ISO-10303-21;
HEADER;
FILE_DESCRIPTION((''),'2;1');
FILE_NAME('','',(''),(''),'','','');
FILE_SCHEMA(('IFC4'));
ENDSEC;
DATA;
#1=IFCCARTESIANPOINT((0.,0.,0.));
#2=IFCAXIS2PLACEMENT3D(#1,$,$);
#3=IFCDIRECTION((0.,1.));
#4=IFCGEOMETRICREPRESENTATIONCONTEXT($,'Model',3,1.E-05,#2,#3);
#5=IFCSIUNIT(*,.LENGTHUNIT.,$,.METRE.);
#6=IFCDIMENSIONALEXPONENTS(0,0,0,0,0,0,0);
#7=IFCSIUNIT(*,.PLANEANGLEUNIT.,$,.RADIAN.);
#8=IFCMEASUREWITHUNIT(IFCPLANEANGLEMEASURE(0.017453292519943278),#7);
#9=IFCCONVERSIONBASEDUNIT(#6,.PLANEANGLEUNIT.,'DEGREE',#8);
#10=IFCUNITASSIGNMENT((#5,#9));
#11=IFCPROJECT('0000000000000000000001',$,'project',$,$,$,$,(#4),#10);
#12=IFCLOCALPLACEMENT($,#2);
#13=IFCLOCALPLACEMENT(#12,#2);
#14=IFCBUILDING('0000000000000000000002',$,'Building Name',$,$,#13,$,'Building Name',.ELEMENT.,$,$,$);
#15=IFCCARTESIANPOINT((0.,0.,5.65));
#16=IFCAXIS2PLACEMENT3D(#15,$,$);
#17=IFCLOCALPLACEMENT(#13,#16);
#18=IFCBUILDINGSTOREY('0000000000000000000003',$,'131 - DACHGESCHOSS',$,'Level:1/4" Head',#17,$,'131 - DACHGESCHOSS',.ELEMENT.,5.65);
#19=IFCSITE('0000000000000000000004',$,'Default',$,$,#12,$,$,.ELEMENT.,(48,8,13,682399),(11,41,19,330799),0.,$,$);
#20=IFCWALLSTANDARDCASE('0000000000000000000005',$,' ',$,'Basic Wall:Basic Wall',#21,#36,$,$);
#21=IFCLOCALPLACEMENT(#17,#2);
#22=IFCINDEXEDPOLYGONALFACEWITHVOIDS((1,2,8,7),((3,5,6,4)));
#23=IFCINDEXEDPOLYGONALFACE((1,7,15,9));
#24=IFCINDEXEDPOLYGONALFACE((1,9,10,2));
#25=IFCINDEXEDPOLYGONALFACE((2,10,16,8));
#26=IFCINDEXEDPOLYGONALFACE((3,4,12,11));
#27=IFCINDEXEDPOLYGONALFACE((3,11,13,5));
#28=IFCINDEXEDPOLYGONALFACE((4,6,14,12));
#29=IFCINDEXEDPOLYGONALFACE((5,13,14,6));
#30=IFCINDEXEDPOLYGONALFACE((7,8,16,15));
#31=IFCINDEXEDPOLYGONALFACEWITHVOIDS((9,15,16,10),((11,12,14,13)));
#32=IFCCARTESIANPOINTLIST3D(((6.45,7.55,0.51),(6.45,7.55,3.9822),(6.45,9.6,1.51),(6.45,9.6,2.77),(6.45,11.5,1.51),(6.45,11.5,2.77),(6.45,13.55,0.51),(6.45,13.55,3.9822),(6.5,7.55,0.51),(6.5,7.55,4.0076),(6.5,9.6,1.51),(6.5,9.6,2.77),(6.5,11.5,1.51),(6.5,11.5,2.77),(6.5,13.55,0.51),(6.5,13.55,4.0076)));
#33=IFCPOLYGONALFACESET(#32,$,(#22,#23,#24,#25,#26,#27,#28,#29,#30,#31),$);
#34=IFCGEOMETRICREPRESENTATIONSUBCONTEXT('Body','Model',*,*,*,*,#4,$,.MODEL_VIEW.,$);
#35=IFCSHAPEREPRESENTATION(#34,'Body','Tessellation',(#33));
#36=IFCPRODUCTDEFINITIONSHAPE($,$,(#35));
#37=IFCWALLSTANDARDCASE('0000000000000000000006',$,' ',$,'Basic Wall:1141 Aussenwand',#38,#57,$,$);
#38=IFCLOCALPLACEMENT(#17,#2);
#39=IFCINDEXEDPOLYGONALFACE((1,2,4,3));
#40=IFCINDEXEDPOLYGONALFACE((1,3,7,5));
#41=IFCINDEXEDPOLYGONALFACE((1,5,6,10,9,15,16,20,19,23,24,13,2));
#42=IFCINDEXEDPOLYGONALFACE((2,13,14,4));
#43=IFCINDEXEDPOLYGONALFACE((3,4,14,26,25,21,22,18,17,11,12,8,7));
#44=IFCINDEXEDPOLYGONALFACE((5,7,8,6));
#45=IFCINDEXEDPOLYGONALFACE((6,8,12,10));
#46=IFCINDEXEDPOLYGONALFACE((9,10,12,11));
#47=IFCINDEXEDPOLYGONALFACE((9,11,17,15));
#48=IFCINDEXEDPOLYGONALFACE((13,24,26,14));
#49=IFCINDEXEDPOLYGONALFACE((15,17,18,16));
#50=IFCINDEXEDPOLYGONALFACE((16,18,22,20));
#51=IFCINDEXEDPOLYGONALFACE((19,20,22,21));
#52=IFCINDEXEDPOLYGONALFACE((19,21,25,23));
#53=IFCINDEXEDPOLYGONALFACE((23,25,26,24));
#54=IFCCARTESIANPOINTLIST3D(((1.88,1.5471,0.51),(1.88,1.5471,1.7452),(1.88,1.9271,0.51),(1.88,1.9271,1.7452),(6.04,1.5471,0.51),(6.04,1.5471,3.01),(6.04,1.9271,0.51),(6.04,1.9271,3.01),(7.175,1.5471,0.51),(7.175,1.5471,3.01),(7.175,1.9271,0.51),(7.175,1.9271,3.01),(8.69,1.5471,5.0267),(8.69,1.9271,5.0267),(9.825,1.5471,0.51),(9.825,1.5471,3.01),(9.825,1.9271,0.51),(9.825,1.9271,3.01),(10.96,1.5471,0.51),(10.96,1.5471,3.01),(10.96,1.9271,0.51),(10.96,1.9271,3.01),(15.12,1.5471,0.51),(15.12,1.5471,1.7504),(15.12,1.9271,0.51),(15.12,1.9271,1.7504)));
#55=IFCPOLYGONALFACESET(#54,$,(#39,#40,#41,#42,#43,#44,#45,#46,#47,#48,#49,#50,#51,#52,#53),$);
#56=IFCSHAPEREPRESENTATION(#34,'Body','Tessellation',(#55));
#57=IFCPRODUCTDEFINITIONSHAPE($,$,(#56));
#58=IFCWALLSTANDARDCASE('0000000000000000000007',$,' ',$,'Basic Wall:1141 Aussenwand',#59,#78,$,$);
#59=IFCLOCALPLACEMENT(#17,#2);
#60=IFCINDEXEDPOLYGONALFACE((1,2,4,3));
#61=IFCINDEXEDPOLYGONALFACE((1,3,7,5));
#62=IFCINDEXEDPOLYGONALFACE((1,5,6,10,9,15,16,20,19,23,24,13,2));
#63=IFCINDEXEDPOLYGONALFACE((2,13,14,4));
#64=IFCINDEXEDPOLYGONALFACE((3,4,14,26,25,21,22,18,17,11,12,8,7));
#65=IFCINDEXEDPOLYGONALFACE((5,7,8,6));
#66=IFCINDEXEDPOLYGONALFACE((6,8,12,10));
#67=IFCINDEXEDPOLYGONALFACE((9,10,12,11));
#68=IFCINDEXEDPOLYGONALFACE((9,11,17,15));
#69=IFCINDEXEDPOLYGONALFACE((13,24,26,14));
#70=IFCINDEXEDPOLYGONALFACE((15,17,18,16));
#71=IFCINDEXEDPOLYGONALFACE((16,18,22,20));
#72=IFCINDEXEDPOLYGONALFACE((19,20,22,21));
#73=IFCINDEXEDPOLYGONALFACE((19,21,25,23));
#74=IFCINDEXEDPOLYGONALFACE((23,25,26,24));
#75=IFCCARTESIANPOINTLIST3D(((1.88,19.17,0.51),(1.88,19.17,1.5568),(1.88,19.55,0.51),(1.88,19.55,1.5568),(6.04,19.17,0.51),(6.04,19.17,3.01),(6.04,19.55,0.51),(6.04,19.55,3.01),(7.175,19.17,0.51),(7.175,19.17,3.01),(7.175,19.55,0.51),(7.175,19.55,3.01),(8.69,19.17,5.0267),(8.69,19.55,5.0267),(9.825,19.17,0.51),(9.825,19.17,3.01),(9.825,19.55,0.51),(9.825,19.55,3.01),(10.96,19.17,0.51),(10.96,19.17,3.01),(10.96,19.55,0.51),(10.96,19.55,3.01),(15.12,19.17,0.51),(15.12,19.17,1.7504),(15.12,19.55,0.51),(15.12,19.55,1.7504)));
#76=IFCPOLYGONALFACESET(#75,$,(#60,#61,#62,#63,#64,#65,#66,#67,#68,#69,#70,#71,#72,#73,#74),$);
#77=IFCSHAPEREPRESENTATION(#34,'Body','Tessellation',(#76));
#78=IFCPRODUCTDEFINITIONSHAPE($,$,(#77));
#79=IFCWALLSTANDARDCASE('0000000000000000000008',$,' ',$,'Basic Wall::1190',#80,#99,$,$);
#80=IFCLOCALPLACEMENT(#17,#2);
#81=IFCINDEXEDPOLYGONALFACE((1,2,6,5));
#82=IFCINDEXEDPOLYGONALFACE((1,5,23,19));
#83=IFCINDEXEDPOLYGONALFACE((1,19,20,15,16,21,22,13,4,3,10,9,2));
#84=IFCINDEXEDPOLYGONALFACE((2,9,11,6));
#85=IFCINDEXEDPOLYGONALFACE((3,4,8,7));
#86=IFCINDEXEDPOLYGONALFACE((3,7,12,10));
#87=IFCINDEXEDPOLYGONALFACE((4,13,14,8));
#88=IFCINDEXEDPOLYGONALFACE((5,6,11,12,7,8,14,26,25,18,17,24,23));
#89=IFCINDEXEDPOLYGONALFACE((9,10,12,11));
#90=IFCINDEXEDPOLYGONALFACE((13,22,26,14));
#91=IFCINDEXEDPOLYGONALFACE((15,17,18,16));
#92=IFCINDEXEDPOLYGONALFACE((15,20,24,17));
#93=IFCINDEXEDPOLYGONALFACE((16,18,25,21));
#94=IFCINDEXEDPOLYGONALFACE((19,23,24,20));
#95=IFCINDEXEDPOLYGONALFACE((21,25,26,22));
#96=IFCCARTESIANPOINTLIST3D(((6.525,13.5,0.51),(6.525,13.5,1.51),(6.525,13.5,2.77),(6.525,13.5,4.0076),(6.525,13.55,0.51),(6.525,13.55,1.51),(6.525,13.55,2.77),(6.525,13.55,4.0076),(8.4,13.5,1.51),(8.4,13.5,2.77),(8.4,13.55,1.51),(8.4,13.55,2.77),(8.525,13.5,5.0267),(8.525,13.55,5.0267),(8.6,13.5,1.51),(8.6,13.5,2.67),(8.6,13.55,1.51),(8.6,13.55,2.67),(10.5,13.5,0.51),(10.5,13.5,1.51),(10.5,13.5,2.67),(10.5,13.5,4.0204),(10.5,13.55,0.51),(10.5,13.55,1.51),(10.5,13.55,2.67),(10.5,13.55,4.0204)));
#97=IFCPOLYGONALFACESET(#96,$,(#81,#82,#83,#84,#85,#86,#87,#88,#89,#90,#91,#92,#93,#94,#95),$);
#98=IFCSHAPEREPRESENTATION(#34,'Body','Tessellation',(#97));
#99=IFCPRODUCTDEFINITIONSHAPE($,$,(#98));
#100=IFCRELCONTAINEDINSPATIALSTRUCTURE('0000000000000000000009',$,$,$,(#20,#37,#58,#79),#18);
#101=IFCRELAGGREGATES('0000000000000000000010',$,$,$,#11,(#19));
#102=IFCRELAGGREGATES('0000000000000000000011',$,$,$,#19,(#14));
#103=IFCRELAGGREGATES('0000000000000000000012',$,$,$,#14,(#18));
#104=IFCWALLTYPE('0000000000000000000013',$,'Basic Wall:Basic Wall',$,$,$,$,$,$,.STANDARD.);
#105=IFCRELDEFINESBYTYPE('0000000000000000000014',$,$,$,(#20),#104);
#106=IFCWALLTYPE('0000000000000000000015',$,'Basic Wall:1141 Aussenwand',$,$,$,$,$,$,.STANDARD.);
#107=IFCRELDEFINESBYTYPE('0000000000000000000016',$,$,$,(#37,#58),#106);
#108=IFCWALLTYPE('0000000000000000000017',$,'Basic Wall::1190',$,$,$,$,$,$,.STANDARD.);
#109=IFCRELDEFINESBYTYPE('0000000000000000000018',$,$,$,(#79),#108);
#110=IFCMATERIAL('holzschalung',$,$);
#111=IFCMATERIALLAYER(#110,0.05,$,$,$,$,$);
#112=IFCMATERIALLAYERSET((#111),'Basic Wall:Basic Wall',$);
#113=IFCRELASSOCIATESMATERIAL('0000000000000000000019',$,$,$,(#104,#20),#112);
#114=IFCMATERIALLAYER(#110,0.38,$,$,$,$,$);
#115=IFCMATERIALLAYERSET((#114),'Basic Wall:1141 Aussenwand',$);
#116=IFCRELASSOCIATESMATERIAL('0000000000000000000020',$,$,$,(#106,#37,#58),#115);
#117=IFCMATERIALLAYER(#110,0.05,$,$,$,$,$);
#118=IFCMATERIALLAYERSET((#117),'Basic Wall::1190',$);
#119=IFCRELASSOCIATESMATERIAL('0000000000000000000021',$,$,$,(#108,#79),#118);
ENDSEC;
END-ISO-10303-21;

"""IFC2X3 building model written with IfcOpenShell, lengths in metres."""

from ifc_helpers import new_model, entity, si_unit, converted_unit, direction, frame, frame_2d, origin, place, context, subcontext, project, spatial, rectangle, extrude, clip, halfspace, material, layer, layer_set, layer_usage, type_object, element, save


model = new_model("IFC2X3")

# Units and contexts
model_context = context("Model", 3, precision=1e-05, world=origin(), true_north=direction((0.0, 1.0)))
body_context = subcontext(model_context, "Body", "Model", "MODEL_VIEW")
ifc_project = project(units=[si_unit("LENGTHUNIT", "METRE"), converted_unit("PLANEANGLEUNIT", "DEGREE", entity("IfcPlaneAngleMeasure", 0.017453292519943278), si_unit("PLANEANGLEUNIT", "RADIAN"), dimensions=[0, 0, 0, 0, 0, 0, 0])], contexts=[model_context])

# Site, building, storey
site_placement = place(None, origin())
site = spatial("IfcSite", under=ifc_project, at=site_placement, Name="Default", CompositionType="ELEMENT", RefLatitude=(48, 8, 13, 682399), RefLongitude=(11, 41, 19, 330799), RefElevation=0.0)
building_placement = place(site_placement, origin())
building = spatial("IfcBuilding", under=site, at=building_placement, Name="Building Name", LongName="Building Name", CompositionType="ELEMENT")
storey_placement = place(building_placement, frame((0.0, 0.0, 5.65)))
storey = spatial("IfcBuildingStorey", under=building, at=storey_placement, Name="131 - DACHGESCHOSS", ObjectType="Level:1/4\" Head", LongName="131 - DACHGESCHOSS", CompositionType="ELEMENT", Elevation=5.65)

# Shared definitions
ifc_material = material(Name="holzschalung")

# Wall, openings
ifc_layer_1 = layer(ifc_material, 0.05)
ifc_layer_set_1 = layer_set([ifc_layer_1], Name="Basic Wall:Basic Wall")
ifc_layer_usage_1 = layer_usage(ifc_layer_set_1, "AXIS2", "NEGATIVE", 0.025)
wall_type_1 = type_object("IfcWallType", Name="Basic Wall:Basic Wall", PredefinedType="STANDARD", material=ifc_layer_set_1)
wall_1_placement = place(storey_placement, frame((6.475, 7.55, 0.51), z_axis=(0.0, 0.0, 1.0), x_axis=(0.0, 1.0, 0.0)))
wall_1 = element("IfcWallStandardCase", 1, at=wall_1_placement, inside=storey, type_object=wall_type_1, material=ifc_layer_usage_1, Name=" ", ObjectType="Basic Wall:Basic Wall", context=body_context, shape_type="SweptSolid", body=[
    extrude(rectangle(XDim=6.0, YDim=0.05, at=frame_2d((3.0, 0.0), x_axis=(-1.0, 0.0))), origin(), (0.0, 0.0, 1.0), 3.4976),
])
opening_1_placement = place(wall_1_placement, origin())
element("IfcOpeningElement", 2, at=opening_1_placement, cuts=wall_1, ObjectType="Opening", context=body_context, shape_type="SweptSolid", body=[
    extrude(rectangle(XDim=6.9075, YDim=13.815, at=frame_2d((0.0, 0.0), x_axis=(1.0, 0.0))), frame((3.0, -3.177, 8.9799), z_axis=(0.0, 0.891007, -0.45399), x_axis=(0.0, -0.45399, -0.891007)), (0.0, 0.0, 1.0), 13.815),
])
opening_2_placement = place(wall_1_placement, origin())
element("IfcOpeningElement", 3, at=opening_2_placement, cuts=wall_1, ObjectType="Opening", context=body_context, shape_type="SweptSolid", body=[
    extrude(rectangle(XDim=1.26, YDim=1.9, at=frame_2d((0.0, 0.0), x_axis=(0.0, 1.0))), frame((3.0, -0.025, 1.63), z_axis=(0.0, 1.0, 0.0), x_axis=(-1.0, 0.0, 0.0)), (0.0, 0.0, 1.0), 0.05),
])

# Shared definitions
ifc_layer_2 = layer(ifc_material, 0.38)
ifc_layer_set_2 = layer_set([ifc_layer_2], Name="Basic Wall:1141 Aussenwand")
wall_type_2 = type_object("IfcWallType", Name="Basic Wall:1141 Aussenwand", PredefinedType="STANDARD", material=ifc_layer_set_2)

# Walls, openings
ifc_layer_usage_2 = layer_usage(ifc_layer_set_2, "AXIS2", "NEGATIVE", 0.19)
wall_2_placement = place(storey_placement, frame((15.12, 1.7371, 0.51), z_axis=(0.0, 0.0, 1.0), x_axis=(-1.0, 0.0, 0.0)))
wall_2 = element("IfcWallStandardCase", 4, at=wall_2_placement, inside=storey, type_object=wall_type_2, material=ifc_layer_usage_2, Name=" ", ObjectType="Basic Wall:1141 Aussenwand", context=body_context, shape_type="Clipping", body=[
    clip(clip(extrude(rectangle(XDim=13.24, YDim=0.38, at=frame_2d((6.62, 0.0), x_axis=(-1.0, 0.0))), origin(), (0.0, 0.0, 1.0), 4.5167), halfspace(frame((0.0, -0.19, 1.2404), z_axis=(-0.45399, 0.0, 0.891007), x_axis=(0.0, 1.0, 0.0)), False)), halfspace(frame((6.43, -0.19, 4.5167), z_axis=(0.434096, 0.0, 0.900866), x_axis=(0.0, 1.0, 0.0)), False)),
])
opening_3_placement = place(wall_2_placement, origin())
element("IfcOpeningElement", 5, at=opening_3_placement, cuts=wall_2, ObjectType="Opening", context=body_context, shape_type="SweptSolid", body=[
    extrude(rectangle(XDim=2.5, YDim=1.135, at=frame_2d((0.0, 0.0), x_axis=(1.0, 0.0))), frame((4.7275, -0.19, 1.25), z_axis=(0.0, 1.0, 0.0), x_axis=(0.0, 0.0, 1.0)), (0.0, 0.0, 1.0), 0.38),
])
opening_4_placement = place(wall_2_placement, origin())
element("IfcOpeningElement", 6, at=opening_4_placement, cuts=wall_2, ObjectType="Opening", context=body_context, shape_type="SweptSolid", body=[
    extrude(rectangle(XDim=2.5, YDim=1.135, at=frame_2d((0.0, 0.0), x_axis=(1.0, 0.0))), frame((8.5125, -0.19, 1.25), z_axis=(0.0, 1.0, 0.0), x_axis=(0.0, 0.0, 1.0)), (0.0, 0.0, 1.0), 0.38),
])
ifc_layer_usage_3 = layer_usage(ifc_layer_set_2, "AXIS2", "NEGATIVE", 0.19)
wall_3_placement = place(storey_placement, frame((1.88, 19.36, 0.51)))
wall_3 = element("IfcWallStandardCase", 7, at=wall_3_placement, inside=storey, type_object=wall_type_2, material=ifc_layer_usage_3, Name=" ", ObjectType="Basic Wall:1141 Aussenwand", context=body_context, shape_type="Clipping", body=[
    clip(clip(extrude(rectangle(XDim=13.24, YDim=0.38, at=frame_2d((6.62, 0.0), x_axis=(-1.0, 0.0))), origin(), (0.0, 0.0, 1.0), 4.5167), halfspace(frame((0.0, -0.19, 1.0468), z_axis=(-0.45399, 0.0, 0.891007), x_axis=(0.0, 1.0, 0.0)), False)), halfspace(frame((6.81, -0.19, 4.5167), z_axis=(0.45399, 0.0, 0.891007), x_axis=(0.0, 1.0, 0.0)), False)),
])
opening_5_placement = place(wall_3_placement, origin())
element("IfcOpeningElement", 8, at=opening_5_placement, cuts=wall_3, ObjectType="Opening", context=body_context, shape_type="SweptSolid", body=[
    extrude(rectangle(XDim=2.5, YDim=1.135, at=frame_2d((0.0, 0.0), x_axis=(1.0, 0.0))), frame((8.5125, -0.19, 1.25), z_axis=(0.0, 1.0, 0.0), x_axis=(0.0, 0.0, 1.0)), (0.0, 0.0, 1.0), 0.38),
])
opening_6_placement = place(wall_3_placement, origin())
element("IfcOpeningElement", 9, at=opening_6_placement, cuts=wall_3, ObjectType="Opening", context=body_context, shape_type="SweptSolid", body=[
    extrude(rectangle(XDim=2.5, YDim=1.135, at=frame_2d((0.0, 0.0), x_axis=(1.0, 0.0))), frame((4.7275, -0.19, 1.25), z_axis=(0.0, 1.0, 0.0), x_axis=(0.0, 0.0, 1.0)), (0.0, 0.0, 1.0), 0.38),
])
ifc_layer_3 = layer(ifc_material, 0.05)
ifc_layer_set_3 = layer_set([ifc_layer_3], Name="Basic Wall::1190")
ifc_layer_usage_4 = layer_usage(ifc_layer_set_3, "AXIS2", "NEGATIVE", 0.025)
wall_type_3 = type_object("IfcWallType", Name="Basic Wall::1190", PredefinedType="STANDARD", material=ifc_layer_set_3)
wall_4_placement = place(storey_placement, frame((6.525, 13.525, 0.51)))
wall_4 = element("IfcWallStandardCase", 10, at=wall_4_placement, inside=storey, type_object=wall_type_3, material=ifc_layer_usage_4, Name=" ", ObjectType="Basic Wall::1190", context=body_context, shape_type="Clipping", body=[
    clip(clip(extrude(rectangle(XDim=3.975, YDim=0.05, at=frame_2d((1.9875, 0.0), x_axis=(-1.0, 0.0))), origin(), (0.0, 0.0, 1.0), 4.5167), halfspace(frame((0.0, -0.025, 3.4976), z_axis=(-0.45399, 0.0, 0.891007), x_axis=(0.0, 1.0, 0.0)), False)), halfspace(frame((2.0, -0.025, 4.5167), z_axis=(0.45399, 0.0, 0.891007), x_axis=(0.0, 1.0, 0.0)), False)),
])
opening_7_placement = place(wall_4_placement, origin())
element("IfcOpeningElement", 11, at=opening_7_placement, cuts=wall_4, ObjectType="Opening", context=body_context, shape_type="SweptSolid", body=[
    extrude(rectangle(XDim=1.26, YDim=1.9, at=frame_2d((0.0, 0.0), x_axis=(0.0, 1.0))), frame((0.925, -0.025, 1.63), z_axis=(0.0, 1.0, 0.0), x_axis=(-1.0, 0.0, 0.0)), (0.0, 0.0, 1.0), 0.05),
])
opening_8_placement = place(wall_4_placement, origin())
element("IfcOpeningElement", 12, at=opening_8_placement, cuts=wall_4, ObjectType="Opening", context=body_context, shape_type="SweptSolid", body=[
    extrude(rectangle(XDim=1.16, YDim=1.9, at=frame_2d((0.0, 0.0), x_axis=(0.0, 1.0))), frame((3.025, -0.025, 1.58), z_axis=(0.0, 1.0, 0.0), x_axis=(-1.0, 0.0, 0.0)), (0.0, 0.0, 1.0), 0.05),
])

save(model, "model.ifc")
